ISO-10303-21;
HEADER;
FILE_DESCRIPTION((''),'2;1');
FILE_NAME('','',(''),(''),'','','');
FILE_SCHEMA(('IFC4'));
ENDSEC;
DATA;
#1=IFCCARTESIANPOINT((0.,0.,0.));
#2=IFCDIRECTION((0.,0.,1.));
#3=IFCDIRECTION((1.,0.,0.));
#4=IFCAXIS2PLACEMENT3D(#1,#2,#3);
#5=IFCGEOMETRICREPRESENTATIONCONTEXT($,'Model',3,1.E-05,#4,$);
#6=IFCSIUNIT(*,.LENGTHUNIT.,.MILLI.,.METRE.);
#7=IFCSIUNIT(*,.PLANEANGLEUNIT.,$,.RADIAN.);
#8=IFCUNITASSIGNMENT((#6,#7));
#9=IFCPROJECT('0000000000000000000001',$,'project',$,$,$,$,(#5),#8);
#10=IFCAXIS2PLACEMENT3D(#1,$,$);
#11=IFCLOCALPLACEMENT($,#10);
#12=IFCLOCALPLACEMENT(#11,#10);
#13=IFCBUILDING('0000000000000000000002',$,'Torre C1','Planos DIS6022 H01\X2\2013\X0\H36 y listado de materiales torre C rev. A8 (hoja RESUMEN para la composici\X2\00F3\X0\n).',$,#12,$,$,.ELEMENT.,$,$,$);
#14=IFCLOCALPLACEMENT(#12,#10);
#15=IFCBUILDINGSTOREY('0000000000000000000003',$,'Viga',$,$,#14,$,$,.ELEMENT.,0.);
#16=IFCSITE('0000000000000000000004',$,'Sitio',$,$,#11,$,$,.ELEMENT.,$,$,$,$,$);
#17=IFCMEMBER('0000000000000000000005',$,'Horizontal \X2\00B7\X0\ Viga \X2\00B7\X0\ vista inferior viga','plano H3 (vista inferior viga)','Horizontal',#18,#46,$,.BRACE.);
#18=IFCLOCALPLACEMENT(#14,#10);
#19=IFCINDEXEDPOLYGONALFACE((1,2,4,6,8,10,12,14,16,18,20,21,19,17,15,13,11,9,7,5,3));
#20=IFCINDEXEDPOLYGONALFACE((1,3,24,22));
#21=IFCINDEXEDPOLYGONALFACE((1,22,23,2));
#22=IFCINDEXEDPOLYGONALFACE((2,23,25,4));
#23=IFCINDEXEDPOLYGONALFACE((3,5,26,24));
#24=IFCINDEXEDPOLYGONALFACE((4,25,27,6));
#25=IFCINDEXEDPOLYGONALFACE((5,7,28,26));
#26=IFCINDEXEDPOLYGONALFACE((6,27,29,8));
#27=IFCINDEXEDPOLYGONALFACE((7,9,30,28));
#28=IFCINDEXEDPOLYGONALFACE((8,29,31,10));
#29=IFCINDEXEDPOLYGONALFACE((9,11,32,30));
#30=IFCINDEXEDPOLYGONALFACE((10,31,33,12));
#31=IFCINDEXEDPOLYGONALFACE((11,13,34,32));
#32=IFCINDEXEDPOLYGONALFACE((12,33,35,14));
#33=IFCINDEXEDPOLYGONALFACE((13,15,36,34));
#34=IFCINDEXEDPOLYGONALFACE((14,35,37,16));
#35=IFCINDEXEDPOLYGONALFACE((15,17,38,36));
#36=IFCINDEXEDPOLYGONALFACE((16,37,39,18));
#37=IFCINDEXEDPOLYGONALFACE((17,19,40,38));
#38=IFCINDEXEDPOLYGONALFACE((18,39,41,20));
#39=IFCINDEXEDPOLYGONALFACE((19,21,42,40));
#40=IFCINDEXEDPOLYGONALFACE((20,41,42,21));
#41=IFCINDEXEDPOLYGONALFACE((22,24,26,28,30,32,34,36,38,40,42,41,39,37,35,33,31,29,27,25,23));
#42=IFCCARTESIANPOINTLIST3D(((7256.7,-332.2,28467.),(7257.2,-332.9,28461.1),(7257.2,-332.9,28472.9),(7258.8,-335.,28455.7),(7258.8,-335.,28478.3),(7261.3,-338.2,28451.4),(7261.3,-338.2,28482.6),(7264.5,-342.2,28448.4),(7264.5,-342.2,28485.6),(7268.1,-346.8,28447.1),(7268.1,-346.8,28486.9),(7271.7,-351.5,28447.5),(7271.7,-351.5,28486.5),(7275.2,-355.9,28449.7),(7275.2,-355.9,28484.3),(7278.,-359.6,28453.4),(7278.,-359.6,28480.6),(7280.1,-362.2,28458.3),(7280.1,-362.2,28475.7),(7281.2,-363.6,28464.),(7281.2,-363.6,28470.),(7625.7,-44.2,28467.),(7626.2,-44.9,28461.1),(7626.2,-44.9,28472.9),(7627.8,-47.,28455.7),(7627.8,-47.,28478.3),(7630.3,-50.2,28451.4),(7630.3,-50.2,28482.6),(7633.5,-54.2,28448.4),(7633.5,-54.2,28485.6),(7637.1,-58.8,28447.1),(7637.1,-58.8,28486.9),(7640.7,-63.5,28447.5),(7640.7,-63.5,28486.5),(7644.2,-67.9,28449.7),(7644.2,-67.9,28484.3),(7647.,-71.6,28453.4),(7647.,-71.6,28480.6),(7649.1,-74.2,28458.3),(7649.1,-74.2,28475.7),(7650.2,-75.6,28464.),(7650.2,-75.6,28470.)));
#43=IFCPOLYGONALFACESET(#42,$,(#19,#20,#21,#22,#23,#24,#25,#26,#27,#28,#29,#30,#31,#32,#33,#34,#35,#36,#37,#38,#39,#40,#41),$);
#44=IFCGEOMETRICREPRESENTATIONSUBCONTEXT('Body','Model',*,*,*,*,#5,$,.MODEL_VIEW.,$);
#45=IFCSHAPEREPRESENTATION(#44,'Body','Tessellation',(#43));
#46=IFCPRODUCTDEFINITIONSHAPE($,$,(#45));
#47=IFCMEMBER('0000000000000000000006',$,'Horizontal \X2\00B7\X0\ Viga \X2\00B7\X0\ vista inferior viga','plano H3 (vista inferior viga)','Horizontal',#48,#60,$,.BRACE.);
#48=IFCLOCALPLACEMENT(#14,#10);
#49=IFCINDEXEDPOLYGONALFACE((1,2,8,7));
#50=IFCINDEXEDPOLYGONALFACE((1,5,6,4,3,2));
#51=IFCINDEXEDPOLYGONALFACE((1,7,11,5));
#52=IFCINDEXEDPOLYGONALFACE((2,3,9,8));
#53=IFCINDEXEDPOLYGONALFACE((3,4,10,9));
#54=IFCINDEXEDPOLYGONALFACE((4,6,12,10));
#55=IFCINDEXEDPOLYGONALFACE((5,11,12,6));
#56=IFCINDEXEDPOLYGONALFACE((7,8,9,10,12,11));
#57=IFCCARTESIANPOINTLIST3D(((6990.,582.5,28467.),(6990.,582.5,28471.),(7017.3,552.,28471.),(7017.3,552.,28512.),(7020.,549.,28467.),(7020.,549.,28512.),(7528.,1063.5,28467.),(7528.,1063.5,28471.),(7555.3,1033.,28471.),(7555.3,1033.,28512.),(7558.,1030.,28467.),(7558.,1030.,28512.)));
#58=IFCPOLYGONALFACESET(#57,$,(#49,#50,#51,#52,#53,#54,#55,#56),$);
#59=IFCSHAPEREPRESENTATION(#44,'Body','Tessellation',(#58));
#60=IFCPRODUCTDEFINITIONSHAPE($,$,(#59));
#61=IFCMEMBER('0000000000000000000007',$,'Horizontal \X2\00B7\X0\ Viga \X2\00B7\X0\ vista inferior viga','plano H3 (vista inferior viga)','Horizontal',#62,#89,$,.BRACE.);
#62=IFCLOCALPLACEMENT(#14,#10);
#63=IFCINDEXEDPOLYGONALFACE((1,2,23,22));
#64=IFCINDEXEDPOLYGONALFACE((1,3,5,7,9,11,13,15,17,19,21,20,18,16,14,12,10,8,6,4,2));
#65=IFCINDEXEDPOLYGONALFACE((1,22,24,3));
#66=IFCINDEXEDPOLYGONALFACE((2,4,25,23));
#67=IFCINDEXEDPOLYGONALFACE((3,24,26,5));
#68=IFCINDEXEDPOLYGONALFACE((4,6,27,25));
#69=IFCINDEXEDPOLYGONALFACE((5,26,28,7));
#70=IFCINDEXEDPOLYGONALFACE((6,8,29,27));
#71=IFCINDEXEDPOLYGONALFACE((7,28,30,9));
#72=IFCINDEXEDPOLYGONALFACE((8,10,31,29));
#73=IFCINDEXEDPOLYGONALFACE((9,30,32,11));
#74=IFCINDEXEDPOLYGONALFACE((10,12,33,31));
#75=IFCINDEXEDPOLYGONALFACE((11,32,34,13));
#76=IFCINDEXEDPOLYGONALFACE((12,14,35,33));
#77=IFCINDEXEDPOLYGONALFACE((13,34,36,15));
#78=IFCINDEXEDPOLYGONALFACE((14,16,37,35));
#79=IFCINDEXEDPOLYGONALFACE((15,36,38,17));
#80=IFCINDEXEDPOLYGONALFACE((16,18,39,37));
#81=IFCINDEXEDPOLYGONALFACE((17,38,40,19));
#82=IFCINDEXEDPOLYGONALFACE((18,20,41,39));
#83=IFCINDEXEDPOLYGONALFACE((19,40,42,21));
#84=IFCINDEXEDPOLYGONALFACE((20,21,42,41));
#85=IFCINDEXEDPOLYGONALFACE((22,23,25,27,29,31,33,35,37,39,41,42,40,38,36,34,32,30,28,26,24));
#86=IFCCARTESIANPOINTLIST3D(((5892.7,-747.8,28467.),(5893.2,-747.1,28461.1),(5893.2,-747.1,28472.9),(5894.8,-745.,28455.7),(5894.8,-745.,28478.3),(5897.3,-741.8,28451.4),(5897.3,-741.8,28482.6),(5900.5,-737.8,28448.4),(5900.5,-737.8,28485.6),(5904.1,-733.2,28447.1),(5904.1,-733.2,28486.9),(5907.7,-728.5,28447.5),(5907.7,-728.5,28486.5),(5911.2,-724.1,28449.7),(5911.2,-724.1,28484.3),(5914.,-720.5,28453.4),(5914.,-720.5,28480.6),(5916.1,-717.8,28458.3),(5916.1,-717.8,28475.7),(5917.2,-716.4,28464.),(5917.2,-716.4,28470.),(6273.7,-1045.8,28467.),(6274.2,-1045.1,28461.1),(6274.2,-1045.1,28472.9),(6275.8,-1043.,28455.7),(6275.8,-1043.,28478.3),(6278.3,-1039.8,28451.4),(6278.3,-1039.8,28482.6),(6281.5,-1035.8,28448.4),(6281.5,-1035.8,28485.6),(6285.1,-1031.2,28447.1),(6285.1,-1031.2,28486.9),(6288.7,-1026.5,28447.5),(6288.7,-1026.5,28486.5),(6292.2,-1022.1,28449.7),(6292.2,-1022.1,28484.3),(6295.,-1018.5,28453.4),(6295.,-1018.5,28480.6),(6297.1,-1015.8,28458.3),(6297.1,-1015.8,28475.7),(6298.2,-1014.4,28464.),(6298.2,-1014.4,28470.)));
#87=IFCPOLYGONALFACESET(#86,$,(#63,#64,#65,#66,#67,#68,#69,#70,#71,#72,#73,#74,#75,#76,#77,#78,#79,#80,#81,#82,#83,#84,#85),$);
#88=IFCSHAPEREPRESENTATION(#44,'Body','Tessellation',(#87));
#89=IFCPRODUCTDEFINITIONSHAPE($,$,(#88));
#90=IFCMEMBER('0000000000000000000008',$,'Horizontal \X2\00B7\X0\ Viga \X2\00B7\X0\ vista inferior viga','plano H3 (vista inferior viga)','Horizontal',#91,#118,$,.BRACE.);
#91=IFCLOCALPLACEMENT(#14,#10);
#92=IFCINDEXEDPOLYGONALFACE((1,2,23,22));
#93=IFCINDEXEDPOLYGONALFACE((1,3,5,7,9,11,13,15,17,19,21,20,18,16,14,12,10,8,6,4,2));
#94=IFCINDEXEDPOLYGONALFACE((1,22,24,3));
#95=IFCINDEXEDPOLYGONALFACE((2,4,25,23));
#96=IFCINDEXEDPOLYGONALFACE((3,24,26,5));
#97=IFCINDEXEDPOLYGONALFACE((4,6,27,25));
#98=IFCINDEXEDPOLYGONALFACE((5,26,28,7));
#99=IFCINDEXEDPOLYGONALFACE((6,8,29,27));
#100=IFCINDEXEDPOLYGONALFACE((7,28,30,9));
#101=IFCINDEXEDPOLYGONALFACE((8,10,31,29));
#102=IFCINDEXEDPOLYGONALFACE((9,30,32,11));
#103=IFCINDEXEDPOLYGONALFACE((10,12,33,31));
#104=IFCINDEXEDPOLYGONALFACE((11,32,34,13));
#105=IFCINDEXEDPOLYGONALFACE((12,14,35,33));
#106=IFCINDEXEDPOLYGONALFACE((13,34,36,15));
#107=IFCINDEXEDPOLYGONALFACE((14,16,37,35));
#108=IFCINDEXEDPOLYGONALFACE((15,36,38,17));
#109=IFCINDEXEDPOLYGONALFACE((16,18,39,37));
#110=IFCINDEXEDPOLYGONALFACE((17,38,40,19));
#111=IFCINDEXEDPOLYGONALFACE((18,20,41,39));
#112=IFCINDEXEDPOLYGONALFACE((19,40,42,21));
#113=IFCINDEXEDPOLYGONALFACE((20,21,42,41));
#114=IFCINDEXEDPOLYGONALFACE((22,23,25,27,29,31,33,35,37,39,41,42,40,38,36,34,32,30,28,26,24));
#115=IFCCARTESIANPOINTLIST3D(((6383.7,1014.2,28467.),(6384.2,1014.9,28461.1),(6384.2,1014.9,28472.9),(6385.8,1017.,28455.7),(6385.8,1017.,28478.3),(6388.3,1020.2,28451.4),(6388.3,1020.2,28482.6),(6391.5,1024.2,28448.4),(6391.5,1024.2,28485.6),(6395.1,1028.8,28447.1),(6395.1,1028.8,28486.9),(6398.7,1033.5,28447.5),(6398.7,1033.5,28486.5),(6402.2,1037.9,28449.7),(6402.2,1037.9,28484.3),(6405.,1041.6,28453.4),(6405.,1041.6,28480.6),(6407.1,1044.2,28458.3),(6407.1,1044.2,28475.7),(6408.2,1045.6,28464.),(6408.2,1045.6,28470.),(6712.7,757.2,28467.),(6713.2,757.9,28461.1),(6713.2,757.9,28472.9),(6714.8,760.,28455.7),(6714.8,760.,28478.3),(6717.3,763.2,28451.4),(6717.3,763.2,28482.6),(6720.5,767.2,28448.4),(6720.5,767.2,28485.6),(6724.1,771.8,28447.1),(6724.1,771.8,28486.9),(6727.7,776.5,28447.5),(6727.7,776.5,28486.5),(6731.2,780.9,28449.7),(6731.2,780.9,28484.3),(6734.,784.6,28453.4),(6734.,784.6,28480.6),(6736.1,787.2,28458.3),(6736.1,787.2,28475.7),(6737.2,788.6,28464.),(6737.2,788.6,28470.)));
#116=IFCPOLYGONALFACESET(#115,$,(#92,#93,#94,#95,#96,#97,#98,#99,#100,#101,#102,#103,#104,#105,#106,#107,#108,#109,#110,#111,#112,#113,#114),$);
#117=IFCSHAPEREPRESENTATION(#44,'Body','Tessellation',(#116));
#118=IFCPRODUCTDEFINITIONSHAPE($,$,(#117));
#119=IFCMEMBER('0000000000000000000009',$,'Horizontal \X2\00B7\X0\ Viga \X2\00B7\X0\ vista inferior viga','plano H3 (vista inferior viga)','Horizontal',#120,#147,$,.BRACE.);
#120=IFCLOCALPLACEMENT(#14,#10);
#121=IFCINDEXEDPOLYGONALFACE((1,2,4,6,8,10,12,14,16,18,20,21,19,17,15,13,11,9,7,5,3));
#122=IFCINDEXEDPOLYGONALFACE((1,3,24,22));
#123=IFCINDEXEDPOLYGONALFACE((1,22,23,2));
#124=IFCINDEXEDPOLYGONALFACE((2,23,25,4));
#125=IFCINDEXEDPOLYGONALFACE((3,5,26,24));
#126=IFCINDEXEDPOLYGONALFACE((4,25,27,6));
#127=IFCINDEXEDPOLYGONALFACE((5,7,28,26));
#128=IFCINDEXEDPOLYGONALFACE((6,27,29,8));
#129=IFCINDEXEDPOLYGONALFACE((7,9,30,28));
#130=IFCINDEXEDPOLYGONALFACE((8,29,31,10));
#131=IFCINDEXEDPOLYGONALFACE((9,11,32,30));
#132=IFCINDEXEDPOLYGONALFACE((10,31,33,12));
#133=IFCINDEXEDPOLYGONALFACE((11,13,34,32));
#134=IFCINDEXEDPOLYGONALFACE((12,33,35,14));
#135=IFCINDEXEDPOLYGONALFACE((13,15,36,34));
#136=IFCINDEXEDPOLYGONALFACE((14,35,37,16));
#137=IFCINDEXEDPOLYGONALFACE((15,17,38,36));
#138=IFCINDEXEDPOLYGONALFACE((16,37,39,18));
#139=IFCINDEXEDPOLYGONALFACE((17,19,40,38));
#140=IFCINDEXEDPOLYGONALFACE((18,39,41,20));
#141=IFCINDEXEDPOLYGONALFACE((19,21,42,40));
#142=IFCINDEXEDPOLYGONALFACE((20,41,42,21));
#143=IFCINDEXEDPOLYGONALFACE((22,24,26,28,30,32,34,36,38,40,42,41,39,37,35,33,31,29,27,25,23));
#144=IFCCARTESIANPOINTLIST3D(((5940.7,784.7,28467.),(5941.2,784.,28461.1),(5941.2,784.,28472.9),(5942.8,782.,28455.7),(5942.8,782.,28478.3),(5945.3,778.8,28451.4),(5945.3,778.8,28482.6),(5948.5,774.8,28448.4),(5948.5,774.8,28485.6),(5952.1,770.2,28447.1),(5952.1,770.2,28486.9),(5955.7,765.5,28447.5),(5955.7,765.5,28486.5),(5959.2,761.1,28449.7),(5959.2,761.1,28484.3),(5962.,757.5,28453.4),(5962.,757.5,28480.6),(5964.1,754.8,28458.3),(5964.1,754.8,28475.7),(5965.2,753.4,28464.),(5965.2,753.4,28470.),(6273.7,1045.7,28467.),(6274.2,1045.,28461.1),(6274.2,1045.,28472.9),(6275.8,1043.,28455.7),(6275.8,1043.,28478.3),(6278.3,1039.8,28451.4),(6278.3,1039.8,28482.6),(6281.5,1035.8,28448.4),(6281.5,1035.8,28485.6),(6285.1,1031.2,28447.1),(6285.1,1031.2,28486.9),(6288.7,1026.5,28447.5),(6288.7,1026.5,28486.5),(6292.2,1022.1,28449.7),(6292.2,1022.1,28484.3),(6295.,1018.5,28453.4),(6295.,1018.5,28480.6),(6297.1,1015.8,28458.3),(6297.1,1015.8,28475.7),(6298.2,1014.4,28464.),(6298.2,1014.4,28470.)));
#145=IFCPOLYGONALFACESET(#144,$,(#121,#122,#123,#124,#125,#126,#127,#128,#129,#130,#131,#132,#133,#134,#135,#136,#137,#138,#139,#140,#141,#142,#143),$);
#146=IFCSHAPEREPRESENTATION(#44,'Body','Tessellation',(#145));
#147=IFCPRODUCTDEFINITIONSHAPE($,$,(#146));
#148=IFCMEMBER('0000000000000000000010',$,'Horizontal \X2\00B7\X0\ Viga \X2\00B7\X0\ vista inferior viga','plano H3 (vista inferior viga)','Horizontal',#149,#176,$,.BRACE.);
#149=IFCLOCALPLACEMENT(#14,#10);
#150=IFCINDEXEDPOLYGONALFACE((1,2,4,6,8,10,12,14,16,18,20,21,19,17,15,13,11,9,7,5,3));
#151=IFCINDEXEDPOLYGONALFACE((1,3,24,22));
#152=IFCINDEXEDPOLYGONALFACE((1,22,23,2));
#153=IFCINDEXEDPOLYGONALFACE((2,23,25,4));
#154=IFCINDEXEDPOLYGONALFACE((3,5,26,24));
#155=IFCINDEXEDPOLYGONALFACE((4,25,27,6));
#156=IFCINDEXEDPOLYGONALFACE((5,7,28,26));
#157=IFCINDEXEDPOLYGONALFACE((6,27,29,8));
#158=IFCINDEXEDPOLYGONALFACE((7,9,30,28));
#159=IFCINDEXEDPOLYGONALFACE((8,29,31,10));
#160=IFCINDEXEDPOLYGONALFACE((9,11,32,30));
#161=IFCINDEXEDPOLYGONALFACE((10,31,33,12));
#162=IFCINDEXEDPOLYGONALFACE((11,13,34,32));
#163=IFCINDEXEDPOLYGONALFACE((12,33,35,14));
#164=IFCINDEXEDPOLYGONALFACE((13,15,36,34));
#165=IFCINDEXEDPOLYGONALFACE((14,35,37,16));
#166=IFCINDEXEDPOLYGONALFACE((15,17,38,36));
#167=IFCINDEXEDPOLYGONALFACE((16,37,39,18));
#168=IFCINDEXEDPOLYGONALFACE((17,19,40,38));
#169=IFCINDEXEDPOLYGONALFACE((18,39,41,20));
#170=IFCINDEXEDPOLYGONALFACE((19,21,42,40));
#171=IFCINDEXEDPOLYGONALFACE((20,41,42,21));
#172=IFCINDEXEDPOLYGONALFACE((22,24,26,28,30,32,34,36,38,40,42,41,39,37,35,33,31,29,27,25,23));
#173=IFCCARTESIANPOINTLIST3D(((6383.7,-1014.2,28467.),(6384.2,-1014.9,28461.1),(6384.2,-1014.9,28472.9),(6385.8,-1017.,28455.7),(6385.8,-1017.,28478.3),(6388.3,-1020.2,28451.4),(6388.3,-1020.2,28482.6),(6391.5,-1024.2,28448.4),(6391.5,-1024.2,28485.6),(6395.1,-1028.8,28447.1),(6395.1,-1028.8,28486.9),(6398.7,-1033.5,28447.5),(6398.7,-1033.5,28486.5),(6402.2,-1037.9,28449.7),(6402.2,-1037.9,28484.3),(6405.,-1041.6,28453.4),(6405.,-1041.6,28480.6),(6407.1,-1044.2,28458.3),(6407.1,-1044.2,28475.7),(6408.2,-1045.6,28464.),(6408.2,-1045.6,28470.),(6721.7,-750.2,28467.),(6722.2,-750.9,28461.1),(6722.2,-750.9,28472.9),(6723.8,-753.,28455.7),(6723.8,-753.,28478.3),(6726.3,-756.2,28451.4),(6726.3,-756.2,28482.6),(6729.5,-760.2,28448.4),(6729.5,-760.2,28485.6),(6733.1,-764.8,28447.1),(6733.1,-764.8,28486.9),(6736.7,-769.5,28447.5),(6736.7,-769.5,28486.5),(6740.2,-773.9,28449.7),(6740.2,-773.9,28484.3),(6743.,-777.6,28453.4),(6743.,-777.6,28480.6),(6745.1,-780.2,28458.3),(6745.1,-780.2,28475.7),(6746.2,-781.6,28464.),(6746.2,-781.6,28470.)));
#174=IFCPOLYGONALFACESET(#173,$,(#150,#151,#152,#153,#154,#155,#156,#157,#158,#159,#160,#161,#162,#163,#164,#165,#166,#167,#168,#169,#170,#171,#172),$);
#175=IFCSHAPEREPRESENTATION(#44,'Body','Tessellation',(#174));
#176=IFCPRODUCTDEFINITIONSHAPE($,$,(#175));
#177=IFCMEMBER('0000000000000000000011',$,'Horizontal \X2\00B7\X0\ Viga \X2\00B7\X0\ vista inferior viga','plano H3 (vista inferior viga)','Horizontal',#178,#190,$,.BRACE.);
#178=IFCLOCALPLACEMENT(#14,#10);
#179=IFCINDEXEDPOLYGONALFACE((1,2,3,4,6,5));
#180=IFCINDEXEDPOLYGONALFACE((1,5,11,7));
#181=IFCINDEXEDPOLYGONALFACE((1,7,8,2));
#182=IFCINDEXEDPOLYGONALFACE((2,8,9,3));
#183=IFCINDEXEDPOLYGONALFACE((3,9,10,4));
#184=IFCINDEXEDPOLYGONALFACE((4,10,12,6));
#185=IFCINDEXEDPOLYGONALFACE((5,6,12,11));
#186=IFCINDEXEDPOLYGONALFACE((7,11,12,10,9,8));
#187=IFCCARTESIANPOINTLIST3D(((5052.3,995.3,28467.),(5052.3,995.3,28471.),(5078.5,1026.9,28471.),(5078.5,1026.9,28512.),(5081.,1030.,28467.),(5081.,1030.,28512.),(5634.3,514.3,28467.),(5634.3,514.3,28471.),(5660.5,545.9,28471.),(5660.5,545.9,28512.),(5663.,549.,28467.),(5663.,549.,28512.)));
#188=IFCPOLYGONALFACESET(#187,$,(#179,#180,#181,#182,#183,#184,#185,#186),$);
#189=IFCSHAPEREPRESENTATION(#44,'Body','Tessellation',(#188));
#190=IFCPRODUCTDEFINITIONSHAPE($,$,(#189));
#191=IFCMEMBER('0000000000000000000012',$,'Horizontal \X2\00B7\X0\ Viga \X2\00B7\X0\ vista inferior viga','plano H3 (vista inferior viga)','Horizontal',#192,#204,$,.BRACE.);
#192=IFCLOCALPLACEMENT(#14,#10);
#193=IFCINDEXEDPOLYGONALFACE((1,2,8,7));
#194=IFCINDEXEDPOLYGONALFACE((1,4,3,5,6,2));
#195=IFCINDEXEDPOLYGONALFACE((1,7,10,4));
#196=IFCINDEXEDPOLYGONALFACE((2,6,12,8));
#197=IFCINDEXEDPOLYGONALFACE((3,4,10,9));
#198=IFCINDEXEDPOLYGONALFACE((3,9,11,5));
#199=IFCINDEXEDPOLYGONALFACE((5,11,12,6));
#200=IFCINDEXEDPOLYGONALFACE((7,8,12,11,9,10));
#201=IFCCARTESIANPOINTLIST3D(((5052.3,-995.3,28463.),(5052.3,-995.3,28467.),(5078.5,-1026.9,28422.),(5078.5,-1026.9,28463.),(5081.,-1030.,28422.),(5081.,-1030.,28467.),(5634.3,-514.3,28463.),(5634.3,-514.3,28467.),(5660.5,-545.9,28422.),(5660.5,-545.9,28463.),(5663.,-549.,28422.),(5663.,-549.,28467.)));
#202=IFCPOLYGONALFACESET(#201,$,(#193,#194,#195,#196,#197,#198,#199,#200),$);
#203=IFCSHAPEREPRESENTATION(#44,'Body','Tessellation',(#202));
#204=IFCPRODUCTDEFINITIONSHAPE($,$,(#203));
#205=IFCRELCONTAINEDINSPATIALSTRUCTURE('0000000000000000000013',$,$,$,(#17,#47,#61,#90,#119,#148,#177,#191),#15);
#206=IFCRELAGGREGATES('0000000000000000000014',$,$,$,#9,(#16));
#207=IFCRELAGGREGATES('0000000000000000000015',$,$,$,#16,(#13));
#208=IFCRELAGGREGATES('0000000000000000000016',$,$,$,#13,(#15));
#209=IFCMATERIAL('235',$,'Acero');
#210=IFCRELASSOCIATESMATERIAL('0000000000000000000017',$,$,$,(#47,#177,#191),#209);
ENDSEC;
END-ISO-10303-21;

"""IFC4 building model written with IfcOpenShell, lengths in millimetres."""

from ifc_helpers import new_model, si_unit, frame, frame_2d, origin, origin_with_axes, place, context, subcontext, project, spatial, circle, l_section, extrude, material, element, save


model = new_model("IFC4")

# Units and contexts
model_context = context("Model", 3, precision=1e-05, world=origin_with_axes())
body_context = subcontext(model_context, "Body", "Model", "MODEL_VIEW")
ifc_project = project(units=[si_unit("LENGTHUNIT", "METRE", prefix="MILLI"), si_unit("PLANEANGLEUNIT", "RADIAN")], contexts=[model_context])

# Site, building, storey
site_placement = place(None, origin())
site = spatial("IfcSite", under=ifc_project, at=site_placement, Name="Sitio", CompositionType="ELEMENT")
building_placement = place(site_placement, origin())
building = spatial("IfcBuilding", under=site, at=building_placement, Name="Torre C1", Description="Planos DIS6022 H01–H36 y listado de materiales torre C rev. A8 (hoja RESUMEN para la composición).", CompositionType="ELEMENT")
storey_placement = place(building_placement, origin())
storey = spatial("IfcBuildingStorey", under=building, at=storey_placement, Name="Viga", CompositionType="ELEMENT", Elevation=0.0)

# Members
ifc_material_1 = material(Name="235", Category="Acero")
member_1_placement = place(storey_placement, frame((7638.0, -60.0, 28467.0), z_axis=(-0.788316, -0.615271, 0.0), x_axis=(-0.615271, 0.788316, 0.0)))
element("IfcMember", 1, at=member_1_placement, inside=storey, Name="Horizontal · Viga · vista inferior viga", Description="plano H3 (vista inferior viga)", ObjectType="Horizontal", PredefinedType="BRACE", context=body_context, shape_type="SweptSolid", body=[
    extrude(circle(Radius=20.0), None, (0.0, 0.0, 1.0), 468.1),
])
member_2_placement = place(storey_placement, frame((7020.0, 549.0, 28467.0), z_axis=(0.745495, 0.666511, 0.0), x_axis=(-0.666511, 0.745495, 0.0)))
element("IfcMember", 2, at=member_2_placement, inside=storey, material=ifc_material_1, Name="Horizontal · Viga · vista inferior viga", Description="plano H3 (vista inferior viga)", ObjectType="Horizontal", PredefinedType="BRACE", context=body_context, shape_type="SweptSolid", body=[
    extrude(l_section(Depth=45.0, Width=45.0, Thickness=4.0, at=frame_2d((22.5, 22.5))), None, (0.0, 0.0, 1.0), 721.7),
])
member_3_placement = place(storey_placement, frame((5905.0, -732.0, 28467.0), z_axis=(0.787679, -0.616085, 0.0), x_axis=(-0.616085, -0.787679, 0.0)))
element("IfcMember", 3, at=member_3_placement, inside=storey, Name="Horizontal · Viga · vista inferior viga", Description="plano H3 (vista inferior viga)", ObjectType="Horizontal", PredefinedType="BRACE", context=body_context, shape_type="SweptSolid", body=[
    extrude(circle(Radius=20.0), None, (0.0, 0.0, 1.0), 483.7),
])
member_4_placement = place(storey_placement, frame((6725.0, 773.0, 28467.0), z_axis=(-0.788061, 0.615598, 0.0), x_axis=(-0.615598, -0.788061, 0.0)))
element("IfcMember", 4, at=member_4_placement, inside=storey, Name="Horizontal · Viga · vista inferior viga", Description="plano H3 (vista inferior viga)", ObjectType="Horizontal", PredefinedType="BRACE", context=body_context, shape_type="SweptSolid", body=[
    extrude(circle(Radius=20.0), None, (0.0, 0.0, 1.0), 417.5),
])
member_5_placement = place(storey_placement, frame((5953.0, 769.0, 28467.0), z_axis=(0.787056, 0.616882, 0.0), x_axis=(-0.616882, 0.787056, 0.0)))
element("IfcMember", 5, at=member_5_placement, inside=storey, Name="Horizontal · Viga · vista inferior viga", Description="plano H3 (vista inferior viga)", ObjectType="Horizontal", PredefinedType="BRACE", context=body_context, shape_type="SweptSolid", body=[
    extrude(circle(Radius=20.0), None, (0.0, 0.0, 1.0), 423.1),
])
member_6_placement = place(storey_placement, frame((6734.0, -766.0, 28467.0), z_axis=(-0.788095, -0.615554, 0.0), x_axis=(-0.615554, 0.788095, 0.0)))
element("IfcMember", 6, at=member_6_placement, inside=storey, Name="Horizontal · Viga · vista inferior viga", Description="plano H3 (vista inferior viga)", ObjectType="Horizontal", PredefinedType="BRACE", context=body_context, shape_type="SweptSolid", body=[
    extrude(circle(Radius=20.0), None, (0.0, 0.0, 1.0), 428.9),
])
for number, where, z_axis, x_axis, name in (
    (7, (5663.0, 549.0, 28467.0), (-0.77082, 0.637053, 0.0), (-0.637053, -0.77082, 0.0), "Horizontal · Viga · vista inferior viga"),
    (8, (5663.0, -549.0, 28467.0), (-0.77082, -0.637053, 0.0), (-0.637053, 0.77082, 0.0), "Horizontal · Viga · vista inferior viga"),
):
    element("IfcMember", number, at=place(storey_placement, frame(where, z_axis=z_axis, x_axis=x_axis)), inside=storey, material=ifc_material_1, Name=name, Description="plano H3 (vista inferior viga)", ObjectType="Horizontal", PredefinedType="BRACE", context=body_context, shape_type="SweptSolid", body=[
        extrude(l_section(Depth=45.0, Width=45.0, Thickness=4.0, at=frame_2d((22.5, 22.5))), None, (0.0, 0.0, 1.0), 755.0),
    ])

save(model, "model.ifc")
